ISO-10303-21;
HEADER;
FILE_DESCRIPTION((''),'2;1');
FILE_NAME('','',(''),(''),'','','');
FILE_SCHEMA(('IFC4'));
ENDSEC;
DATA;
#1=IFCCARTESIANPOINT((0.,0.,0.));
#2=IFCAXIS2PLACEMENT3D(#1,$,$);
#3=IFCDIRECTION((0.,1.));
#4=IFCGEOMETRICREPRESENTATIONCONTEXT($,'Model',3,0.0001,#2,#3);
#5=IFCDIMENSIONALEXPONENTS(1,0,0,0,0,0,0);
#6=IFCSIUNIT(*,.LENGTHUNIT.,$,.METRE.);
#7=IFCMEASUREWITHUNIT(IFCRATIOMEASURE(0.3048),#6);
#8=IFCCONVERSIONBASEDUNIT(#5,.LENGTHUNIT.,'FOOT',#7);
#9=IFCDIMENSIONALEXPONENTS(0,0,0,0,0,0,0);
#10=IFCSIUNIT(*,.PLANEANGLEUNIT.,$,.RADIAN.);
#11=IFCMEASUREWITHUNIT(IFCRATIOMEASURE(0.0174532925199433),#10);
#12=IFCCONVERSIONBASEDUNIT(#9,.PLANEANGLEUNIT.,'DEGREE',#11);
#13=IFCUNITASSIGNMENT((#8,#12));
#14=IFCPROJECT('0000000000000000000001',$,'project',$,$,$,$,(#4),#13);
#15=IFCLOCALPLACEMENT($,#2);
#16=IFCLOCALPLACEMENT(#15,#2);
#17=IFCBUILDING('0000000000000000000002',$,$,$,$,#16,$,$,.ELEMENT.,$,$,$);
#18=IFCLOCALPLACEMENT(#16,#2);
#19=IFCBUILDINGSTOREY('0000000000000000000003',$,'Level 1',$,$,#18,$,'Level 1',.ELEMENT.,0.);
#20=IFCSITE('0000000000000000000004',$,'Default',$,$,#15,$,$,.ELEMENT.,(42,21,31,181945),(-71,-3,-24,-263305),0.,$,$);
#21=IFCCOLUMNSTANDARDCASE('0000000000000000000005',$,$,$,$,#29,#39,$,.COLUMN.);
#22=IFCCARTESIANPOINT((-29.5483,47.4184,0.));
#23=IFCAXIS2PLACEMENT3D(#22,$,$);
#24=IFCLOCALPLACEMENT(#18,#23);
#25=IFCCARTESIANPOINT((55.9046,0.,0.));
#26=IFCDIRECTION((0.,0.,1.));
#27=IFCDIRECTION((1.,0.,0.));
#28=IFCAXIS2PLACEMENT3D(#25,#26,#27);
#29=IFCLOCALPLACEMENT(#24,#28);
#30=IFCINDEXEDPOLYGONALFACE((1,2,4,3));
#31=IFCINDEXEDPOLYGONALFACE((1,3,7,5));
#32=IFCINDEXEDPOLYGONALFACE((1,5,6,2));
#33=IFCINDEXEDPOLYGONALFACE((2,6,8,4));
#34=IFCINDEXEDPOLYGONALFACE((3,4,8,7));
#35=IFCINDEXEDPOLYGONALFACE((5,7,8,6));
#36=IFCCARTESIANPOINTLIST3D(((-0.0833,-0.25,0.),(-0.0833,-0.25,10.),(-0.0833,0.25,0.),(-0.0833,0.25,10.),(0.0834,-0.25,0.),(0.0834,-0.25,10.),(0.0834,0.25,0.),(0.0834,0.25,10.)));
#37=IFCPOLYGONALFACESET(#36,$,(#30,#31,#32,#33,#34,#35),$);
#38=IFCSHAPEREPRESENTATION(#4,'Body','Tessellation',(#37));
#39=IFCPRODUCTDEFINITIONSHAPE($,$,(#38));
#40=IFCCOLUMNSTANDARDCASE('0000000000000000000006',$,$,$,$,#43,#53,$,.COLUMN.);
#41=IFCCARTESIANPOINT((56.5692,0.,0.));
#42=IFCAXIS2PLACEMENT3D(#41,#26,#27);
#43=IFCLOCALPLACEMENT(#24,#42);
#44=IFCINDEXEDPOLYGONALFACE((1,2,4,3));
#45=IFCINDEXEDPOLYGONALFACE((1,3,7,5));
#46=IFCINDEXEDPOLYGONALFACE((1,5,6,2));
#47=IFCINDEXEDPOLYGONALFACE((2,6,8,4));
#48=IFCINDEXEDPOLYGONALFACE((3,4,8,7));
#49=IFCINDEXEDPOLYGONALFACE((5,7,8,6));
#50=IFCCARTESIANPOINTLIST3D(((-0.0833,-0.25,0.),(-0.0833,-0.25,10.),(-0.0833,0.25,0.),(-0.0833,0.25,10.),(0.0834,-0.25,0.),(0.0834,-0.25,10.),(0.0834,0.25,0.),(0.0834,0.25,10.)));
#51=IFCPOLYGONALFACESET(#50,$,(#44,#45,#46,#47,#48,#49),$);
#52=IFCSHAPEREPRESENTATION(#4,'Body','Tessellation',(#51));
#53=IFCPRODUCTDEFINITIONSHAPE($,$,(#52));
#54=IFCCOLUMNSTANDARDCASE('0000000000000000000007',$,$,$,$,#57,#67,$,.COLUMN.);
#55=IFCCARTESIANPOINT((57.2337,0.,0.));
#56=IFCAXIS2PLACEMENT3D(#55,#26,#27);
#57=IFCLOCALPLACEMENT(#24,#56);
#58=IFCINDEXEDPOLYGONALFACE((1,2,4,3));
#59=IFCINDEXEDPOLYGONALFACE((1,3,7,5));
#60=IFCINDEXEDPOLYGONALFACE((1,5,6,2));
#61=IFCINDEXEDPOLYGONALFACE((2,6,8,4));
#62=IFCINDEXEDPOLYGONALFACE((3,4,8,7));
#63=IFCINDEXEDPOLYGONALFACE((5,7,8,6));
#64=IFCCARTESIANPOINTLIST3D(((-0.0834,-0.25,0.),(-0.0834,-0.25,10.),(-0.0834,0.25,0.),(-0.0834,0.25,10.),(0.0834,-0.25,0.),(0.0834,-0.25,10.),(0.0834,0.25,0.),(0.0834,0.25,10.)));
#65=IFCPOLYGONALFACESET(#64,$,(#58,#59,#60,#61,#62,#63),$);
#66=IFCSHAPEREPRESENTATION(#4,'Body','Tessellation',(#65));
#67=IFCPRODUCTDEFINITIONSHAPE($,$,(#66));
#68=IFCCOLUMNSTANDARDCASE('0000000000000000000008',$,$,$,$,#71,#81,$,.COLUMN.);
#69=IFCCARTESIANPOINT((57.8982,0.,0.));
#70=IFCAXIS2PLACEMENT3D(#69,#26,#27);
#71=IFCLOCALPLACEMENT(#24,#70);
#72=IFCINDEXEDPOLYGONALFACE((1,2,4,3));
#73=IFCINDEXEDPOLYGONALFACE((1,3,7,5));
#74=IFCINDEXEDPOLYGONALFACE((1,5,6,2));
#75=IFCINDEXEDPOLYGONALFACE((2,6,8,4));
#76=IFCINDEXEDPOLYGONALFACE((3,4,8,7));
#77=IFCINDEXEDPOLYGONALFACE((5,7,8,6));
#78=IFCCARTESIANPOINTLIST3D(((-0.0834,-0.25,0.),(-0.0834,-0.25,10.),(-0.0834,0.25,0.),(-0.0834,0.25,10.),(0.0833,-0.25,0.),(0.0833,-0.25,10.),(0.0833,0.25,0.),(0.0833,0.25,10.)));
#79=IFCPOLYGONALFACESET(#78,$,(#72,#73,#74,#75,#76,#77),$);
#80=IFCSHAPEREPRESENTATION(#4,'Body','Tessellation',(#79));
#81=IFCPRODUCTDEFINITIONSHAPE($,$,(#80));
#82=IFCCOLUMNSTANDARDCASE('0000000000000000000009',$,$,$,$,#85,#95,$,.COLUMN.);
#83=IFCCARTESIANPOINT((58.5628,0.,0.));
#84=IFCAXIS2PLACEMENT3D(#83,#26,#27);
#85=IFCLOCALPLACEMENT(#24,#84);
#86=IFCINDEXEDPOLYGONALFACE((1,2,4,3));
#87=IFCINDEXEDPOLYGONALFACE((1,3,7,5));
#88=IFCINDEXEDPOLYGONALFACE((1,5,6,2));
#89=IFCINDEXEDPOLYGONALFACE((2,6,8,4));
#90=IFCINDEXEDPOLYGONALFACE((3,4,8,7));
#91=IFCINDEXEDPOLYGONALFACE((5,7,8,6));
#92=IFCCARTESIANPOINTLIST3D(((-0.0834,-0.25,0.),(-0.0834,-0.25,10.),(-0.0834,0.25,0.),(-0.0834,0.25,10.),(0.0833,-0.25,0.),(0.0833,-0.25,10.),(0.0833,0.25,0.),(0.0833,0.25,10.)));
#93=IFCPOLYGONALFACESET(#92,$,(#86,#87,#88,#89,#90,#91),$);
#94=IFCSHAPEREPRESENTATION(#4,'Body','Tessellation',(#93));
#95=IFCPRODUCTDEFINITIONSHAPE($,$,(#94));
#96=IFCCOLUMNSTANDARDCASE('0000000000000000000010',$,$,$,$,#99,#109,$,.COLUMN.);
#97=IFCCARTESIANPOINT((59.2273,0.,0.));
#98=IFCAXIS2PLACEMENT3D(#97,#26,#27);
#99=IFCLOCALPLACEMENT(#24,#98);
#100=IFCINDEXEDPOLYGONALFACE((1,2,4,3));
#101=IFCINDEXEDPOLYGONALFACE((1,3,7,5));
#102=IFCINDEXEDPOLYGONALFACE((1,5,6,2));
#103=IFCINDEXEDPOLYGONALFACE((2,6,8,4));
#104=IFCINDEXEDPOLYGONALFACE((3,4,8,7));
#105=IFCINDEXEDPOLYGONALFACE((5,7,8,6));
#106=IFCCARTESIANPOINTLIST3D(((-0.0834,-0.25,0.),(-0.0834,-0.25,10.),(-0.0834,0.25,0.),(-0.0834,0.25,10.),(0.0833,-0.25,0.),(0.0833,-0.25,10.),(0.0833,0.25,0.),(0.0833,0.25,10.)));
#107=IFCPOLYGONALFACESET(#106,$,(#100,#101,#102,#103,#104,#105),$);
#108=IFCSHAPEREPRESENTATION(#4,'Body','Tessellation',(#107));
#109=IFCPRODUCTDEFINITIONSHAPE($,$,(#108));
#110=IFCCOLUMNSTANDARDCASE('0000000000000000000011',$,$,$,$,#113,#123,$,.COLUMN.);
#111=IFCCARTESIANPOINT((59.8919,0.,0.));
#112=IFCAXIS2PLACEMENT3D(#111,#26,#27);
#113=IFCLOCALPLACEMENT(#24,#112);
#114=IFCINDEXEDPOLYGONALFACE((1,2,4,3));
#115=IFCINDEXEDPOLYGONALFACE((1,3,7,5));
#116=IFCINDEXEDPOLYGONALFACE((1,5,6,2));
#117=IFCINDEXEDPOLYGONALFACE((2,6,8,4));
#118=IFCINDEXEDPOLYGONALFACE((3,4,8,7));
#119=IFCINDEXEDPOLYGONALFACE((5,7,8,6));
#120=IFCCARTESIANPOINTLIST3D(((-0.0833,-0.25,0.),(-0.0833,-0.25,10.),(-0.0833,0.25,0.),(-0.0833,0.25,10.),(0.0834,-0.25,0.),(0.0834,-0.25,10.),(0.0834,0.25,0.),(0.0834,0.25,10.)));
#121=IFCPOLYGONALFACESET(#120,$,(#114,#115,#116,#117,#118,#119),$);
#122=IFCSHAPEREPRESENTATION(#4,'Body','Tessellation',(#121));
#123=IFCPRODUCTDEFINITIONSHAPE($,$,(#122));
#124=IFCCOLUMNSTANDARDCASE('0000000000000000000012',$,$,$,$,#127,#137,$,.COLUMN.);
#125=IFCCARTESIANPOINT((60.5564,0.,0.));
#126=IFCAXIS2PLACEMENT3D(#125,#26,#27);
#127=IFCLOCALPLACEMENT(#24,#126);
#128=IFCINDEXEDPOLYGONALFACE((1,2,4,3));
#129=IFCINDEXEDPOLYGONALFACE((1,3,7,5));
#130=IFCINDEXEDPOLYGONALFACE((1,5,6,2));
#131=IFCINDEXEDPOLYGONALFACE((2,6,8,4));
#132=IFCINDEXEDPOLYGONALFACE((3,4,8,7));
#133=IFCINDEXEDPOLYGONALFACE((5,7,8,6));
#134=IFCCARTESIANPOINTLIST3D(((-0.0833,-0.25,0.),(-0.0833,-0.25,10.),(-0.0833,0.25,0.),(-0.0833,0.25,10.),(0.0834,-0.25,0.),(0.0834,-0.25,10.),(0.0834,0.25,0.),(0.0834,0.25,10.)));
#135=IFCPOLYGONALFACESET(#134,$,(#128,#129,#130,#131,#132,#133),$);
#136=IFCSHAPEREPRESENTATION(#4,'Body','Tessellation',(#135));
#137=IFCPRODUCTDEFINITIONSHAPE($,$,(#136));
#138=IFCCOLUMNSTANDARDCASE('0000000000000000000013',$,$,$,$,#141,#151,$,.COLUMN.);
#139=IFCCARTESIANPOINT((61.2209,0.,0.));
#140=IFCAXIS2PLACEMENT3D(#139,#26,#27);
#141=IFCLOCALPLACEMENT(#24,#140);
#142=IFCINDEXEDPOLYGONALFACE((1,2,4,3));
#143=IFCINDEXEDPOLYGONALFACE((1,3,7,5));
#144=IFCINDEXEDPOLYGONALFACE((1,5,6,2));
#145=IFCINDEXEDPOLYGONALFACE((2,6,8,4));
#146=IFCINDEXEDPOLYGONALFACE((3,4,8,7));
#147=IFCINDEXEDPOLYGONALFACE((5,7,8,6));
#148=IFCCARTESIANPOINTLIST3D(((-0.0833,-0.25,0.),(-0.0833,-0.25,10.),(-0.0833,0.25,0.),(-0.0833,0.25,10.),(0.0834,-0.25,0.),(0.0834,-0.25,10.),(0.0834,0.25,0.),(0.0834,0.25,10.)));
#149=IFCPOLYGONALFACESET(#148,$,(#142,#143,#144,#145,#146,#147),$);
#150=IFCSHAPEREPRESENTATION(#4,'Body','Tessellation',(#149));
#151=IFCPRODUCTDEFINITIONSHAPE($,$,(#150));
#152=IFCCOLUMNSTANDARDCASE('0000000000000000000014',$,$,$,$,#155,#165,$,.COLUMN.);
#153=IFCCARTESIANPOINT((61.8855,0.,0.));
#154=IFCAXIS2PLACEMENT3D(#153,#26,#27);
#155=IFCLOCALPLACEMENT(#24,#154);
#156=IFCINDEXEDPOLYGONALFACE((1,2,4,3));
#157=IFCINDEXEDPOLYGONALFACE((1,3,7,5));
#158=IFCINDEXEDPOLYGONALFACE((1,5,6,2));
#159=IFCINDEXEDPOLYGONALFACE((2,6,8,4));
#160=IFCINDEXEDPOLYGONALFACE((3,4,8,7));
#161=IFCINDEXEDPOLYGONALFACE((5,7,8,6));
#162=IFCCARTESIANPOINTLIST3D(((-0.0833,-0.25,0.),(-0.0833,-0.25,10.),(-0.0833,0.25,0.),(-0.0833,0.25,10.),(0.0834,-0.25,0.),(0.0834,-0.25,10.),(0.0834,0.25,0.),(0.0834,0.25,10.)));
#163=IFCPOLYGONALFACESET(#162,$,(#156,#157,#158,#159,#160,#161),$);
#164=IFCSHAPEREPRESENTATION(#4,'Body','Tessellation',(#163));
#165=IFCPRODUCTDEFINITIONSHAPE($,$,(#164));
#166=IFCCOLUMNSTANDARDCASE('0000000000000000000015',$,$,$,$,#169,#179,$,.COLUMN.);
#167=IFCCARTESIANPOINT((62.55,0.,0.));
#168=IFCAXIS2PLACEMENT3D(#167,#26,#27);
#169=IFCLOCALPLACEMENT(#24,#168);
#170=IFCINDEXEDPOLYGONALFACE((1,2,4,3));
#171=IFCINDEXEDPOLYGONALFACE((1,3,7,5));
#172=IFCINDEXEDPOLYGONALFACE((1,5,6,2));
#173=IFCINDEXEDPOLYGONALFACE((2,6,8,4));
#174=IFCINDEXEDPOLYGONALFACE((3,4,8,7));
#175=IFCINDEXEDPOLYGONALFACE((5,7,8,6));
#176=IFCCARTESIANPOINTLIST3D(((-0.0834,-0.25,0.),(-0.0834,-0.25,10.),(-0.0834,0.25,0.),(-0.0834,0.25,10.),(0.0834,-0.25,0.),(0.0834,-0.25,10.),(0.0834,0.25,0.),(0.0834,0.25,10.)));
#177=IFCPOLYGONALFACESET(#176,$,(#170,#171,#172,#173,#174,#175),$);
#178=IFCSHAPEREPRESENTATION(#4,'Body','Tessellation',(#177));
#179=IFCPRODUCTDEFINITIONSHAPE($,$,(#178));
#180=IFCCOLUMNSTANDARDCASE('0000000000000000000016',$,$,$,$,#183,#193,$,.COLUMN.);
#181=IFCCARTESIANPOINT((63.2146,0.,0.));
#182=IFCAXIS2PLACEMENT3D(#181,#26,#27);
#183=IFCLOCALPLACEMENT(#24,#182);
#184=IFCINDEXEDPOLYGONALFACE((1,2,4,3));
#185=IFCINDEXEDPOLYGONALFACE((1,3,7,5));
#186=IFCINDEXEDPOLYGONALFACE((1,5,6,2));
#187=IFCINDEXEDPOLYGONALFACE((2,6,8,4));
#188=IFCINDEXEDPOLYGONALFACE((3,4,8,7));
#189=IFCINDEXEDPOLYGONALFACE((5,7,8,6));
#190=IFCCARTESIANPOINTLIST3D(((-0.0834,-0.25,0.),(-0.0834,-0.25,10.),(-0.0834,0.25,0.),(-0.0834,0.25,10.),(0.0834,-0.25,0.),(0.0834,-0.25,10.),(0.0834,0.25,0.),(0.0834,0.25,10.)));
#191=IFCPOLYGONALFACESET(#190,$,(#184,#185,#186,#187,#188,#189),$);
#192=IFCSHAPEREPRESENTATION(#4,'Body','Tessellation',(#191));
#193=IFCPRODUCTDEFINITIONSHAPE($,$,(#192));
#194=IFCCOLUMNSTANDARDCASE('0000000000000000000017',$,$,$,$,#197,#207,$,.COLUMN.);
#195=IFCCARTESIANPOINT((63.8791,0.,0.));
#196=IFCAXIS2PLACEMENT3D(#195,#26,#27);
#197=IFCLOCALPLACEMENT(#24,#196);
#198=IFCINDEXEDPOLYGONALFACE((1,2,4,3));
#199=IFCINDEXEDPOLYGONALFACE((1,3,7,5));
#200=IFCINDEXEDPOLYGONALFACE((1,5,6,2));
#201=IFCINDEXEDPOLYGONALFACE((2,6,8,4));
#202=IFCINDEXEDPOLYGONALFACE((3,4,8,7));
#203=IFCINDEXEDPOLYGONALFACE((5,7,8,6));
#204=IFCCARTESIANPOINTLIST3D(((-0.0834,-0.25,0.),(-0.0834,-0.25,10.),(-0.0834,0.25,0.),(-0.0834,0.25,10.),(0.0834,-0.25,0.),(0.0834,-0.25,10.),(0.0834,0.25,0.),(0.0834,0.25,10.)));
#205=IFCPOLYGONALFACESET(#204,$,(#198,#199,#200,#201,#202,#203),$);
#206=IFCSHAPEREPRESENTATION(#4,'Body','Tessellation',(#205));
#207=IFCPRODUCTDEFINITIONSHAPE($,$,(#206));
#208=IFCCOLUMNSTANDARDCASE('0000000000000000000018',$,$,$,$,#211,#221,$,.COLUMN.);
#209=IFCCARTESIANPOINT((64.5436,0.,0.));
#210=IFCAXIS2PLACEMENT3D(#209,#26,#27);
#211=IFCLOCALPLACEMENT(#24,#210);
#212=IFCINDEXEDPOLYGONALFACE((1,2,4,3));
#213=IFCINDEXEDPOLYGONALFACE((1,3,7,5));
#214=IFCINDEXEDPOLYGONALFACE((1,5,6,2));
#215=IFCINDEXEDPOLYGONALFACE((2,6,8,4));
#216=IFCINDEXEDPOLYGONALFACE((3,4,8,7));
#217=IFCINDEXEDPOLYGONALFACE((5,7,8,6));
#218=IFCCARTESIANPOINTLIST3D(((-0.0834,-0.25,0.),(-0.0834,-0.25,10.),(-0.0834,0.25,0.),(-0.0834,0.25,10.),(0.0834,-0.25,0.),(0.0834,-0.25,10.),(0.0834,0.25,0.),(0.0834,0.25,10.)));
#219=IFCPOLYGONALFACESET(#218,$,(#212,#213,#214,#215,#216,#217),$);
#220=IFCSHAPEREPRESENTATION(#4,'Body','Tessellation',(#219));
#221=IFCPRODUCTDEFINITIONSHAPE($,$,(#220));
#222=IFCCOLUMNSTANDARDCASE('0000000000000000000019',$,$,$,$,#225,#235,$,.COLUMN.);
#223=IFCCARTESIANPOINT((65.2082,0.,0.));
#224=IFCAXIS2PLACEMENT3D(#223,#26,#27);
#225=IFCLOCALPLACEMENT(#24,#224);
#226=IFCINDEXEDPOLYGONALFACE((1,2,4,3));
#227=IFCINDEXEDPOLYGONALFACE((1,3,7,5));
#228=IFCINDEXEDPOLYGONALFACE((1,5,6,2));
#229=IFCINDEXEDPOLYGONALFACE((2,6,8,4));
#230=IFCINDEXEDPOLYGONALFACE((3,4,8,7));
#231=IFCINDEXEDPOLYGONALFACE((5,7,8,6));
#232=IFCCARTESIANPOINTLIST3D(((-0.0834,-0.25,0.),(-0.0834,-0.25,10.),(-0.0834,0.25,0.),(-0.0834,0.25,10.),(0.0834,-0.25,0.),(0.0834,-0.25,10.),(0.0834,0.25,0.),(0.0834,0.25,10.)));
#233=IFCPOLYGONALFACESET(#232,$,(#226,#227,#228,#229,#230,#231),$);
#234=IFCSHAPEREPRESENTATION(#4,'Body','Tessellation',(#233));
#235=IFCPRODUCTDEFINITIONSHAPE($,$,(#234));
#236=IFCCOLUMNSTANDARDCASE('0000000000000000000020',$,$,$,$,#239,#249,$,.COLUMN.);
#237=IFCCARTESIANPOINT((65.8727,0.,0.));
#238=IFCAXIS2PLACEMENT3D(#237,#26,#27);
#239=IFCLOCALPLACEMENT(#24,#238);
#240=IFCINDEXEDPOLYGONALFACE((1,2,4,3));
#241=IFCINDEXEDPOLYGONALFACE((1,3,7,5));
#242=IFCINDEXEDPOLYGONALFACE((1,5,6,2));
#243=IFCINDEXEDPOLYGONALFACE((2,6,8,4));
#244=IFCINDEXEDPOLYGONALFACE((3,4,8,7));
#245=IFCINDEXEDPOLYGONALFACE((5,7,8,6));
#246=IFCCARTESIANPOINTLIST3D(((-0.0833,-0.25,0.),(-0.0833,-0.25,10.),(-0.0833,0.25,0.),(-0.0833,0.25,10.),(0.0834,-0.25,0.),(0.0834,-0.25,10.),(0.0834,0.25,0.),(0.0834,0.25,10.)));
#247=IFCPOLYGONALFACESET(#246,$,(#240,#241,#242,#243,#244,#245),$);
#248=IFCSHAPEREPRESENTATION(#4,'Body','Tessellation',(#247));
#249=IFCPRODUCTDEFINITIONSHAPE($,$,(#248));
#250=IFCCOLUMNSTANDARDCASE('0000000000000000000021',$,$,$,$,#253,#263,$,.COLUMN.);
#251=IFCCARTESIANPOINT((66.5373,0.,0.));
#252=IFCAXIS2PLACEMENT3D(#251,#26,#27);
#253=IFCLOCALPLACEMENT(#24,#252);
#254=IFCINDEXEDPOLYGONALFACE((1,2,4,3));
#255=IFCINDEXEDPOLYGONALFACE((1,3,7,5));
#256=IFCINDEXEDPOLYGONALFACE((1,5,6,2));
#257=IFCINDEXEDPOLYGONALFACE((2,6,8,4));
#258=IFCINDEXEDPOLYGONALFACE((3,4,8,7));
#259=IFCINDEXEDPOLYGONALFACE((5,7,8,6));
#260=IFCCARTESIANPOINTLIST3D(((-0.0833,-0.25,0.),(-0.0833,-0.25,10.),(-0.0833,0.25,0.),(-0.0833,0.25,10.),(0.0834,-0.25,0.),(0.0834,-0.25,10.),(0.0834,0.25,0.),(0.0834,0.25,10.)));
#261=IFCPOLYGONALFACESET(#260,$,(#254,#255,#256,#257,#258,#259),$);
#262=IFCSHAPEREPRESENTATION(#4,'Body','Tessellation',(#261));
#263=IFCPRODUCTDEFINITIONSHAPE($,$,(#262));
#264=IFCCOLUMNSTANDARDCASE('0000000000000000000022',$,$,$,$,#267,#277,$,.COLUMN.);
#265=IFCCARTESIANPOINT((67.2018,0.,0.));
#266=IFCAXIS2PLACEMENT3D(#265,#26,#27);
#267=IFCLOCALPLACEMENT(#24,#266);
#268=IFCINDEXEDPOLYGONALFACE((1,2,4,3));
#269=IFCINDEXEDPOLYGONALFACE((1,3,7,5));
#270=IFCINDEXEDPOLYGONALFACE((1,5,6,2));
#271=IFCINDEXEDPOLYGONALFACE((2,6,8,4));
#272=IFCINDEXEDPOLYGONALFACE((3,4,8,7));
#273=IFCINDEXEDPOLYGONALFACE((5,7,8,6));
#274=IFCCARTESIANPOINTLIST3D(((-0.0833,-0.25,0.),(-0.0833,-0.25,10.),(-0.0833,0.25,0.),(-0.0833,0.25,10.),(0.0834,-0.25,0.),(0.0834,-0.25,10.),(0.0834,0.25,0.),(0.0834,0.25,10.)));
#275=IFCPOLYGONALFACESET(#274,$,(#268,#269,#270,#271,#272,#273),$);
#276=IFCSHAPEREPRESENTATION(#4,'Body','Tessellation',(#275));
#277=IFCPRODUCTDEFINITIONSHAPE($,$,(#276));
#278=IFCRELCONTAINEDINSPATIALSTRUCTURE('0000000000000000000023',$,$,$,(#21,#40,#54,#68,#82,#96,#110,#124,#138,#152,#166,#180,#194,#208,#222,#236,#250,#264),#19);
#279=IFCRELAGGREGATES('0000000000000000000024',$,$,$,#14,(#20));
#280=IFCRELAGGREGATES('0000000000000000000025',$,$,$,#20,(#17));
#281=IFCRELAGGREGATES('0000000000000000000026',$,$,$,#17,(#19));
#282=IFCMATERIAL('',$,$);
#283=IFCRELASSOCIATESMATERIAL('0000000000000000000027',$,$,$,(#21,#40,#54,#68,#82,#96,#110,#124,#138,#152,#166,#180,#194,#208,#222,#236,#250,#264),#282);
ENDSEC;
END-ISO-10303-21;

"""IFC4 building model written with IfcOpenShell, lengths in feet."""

from ifc_helpers import new_model, entity, si_unit, converted_unit, direction, frame, origin, place, context, project, spatial, rectangle, extrude, material, element, save


model = new_model("IFC4")

# Units and contexts
model_context = context("Model", 3, precision=0.0001, world=origin(), true_north=direction((0.0, 1.0)))
ifc_project = project(units=[converted_unit("LENGTHUNIT", "FOOT", entity("IfcRatioMeasure", 0.3048), si_unit("LENGTHUNIT", "METRE"), dimensions=[1, 0, 0, 0, 0, 0, 0]), converted_unit("PLANEANGLEUNIT", "DEGREE", entity("IfcRatioMeasure", 0.0174532925199433), si_unit("PLANEANGLEUNIT", "RADIAN"), dimensions=[0, 0, 0, 0, 0, 0, 0])], contexts=[model_context])

# Site, building, storey
site_placement = place(None, origin())
site = spatial("IfcSite", under=ifc_project, at=site_placement, Name="Default", CompositionType="ELEMENT", RefLatitude=(42, 21, 31, 181945), RefLongitude=(-71, -3, -24, -263305), RefElevation=0.0)
building_placement = place(site_placement, origin())
building = spatial("IfcBuilding", under=site, at=building_placement, CompositionType="ELEMENT")
storey_placement = place(building_placement, origin())
storey = spatial("IfcBuildingStorey", under=building, at=storey_placement, Name="Level 1", LongName="Level 1", CompositionType="ELEMENT", Elevation=0.0)

# Columns
ifc_material = material(Name="")
placement = place(storey_placement, frame((-29.5483, 47.4184, 0.0)))
for number, where, z_axis, x_axis in (
    (1, (55.9046, 0.0, 0.0), (0.0, 0.0, 1.0), (1.0, 0.0, 0.0)),
    (2, (56.5692, 0.0, 0.0), (0.0, 0.0, 1.0), (1.0, 0.0, 0.0)),
    (3, (57.2337, 0.0, 0.0), (0.0, 0.0, 1.0), (1.0, 0.0, 0.0)),
    (4, (57.8982, 0.0, 0.0), (0.0, 0.0, 1.0), (1.0, 0.0, 0.0)),
    (5, (58.5628, 0.0, 0.0), (0.0, 0.0, 1.0), (1.0, 0.0, 0.0)),
    (6, (59.2273, 0.0, 0.0), (0.0, 0.0, 1.0), (1.0, 0.0, 0.0)),
    (7, (59.8919, 0.0, 0.0), (0.0, 0.0, 1.0), (1.0, 0.0, 0.0)),
    (8, (60.5564, 0.0, 0.0), (0.0, 0.0, 1.0), (1.0, 0.0, 0.0)),
    (9, (61.2209, 0.0, 0.0), (0.0, 0.0, 1.0), (1.0, 0.0, 0.0)),
    (10, (61.8855, 0.0, 0.0), (0.0, 0.0, 1.0), (1.0, 0.0, 0.0)),
    (11, (62.55, 0.0, 0.0), (0.0, 0.0, 1.0), (1.0, 0.0, 0.0)),
    (12, (63.2146, 0.0, 0.0), (0.0, 0.0, 1.0), (1.0, 0.0, 0.0)),
    (13, (63.8791, 0.0, 0.0), (0.0, 0.0, 1.0), (1.0, 0.0, 0.0)),
    (14, (64.5436, 0.0, 0.0), (0.0, 0.0, 1.0), (1.0, 0.0, 0.0)),
    (15, (65.2082, 0.0, 0.0), (0.0, 0.0, 1.0), (1.0, 0.0, 0.0)),
    (16, (65.8727, 0.0, 0.0), (0.0, 0.0, 1.0), (1.0, 0.0, 0.0)),
    (17, (66.5373, 0.0, 0.0), (0.0, 0.0, 1.0), (1.0, 0.0, 0.0)),
    (18, (67.2018, 0.0, 0.0), (0.0, 0.0, 1.0), (1.0, 0.0, 0.0)),
):
    element("IfcColumnStandardCase", number, at=place(placement, frame(where, z_axis=z_axis, x_axis=x_axis)), inside=storey, material=ifc_material, PredefinedType="COLUMN", context=model_context, shape_type="SweptSolid", body=[
        extrude(rectangle(XDim=0.1667, YDim=0.5), origin(), (0.0, 0.0, 1.0), 10.0),
    ])

save(model, "model.ifc")
